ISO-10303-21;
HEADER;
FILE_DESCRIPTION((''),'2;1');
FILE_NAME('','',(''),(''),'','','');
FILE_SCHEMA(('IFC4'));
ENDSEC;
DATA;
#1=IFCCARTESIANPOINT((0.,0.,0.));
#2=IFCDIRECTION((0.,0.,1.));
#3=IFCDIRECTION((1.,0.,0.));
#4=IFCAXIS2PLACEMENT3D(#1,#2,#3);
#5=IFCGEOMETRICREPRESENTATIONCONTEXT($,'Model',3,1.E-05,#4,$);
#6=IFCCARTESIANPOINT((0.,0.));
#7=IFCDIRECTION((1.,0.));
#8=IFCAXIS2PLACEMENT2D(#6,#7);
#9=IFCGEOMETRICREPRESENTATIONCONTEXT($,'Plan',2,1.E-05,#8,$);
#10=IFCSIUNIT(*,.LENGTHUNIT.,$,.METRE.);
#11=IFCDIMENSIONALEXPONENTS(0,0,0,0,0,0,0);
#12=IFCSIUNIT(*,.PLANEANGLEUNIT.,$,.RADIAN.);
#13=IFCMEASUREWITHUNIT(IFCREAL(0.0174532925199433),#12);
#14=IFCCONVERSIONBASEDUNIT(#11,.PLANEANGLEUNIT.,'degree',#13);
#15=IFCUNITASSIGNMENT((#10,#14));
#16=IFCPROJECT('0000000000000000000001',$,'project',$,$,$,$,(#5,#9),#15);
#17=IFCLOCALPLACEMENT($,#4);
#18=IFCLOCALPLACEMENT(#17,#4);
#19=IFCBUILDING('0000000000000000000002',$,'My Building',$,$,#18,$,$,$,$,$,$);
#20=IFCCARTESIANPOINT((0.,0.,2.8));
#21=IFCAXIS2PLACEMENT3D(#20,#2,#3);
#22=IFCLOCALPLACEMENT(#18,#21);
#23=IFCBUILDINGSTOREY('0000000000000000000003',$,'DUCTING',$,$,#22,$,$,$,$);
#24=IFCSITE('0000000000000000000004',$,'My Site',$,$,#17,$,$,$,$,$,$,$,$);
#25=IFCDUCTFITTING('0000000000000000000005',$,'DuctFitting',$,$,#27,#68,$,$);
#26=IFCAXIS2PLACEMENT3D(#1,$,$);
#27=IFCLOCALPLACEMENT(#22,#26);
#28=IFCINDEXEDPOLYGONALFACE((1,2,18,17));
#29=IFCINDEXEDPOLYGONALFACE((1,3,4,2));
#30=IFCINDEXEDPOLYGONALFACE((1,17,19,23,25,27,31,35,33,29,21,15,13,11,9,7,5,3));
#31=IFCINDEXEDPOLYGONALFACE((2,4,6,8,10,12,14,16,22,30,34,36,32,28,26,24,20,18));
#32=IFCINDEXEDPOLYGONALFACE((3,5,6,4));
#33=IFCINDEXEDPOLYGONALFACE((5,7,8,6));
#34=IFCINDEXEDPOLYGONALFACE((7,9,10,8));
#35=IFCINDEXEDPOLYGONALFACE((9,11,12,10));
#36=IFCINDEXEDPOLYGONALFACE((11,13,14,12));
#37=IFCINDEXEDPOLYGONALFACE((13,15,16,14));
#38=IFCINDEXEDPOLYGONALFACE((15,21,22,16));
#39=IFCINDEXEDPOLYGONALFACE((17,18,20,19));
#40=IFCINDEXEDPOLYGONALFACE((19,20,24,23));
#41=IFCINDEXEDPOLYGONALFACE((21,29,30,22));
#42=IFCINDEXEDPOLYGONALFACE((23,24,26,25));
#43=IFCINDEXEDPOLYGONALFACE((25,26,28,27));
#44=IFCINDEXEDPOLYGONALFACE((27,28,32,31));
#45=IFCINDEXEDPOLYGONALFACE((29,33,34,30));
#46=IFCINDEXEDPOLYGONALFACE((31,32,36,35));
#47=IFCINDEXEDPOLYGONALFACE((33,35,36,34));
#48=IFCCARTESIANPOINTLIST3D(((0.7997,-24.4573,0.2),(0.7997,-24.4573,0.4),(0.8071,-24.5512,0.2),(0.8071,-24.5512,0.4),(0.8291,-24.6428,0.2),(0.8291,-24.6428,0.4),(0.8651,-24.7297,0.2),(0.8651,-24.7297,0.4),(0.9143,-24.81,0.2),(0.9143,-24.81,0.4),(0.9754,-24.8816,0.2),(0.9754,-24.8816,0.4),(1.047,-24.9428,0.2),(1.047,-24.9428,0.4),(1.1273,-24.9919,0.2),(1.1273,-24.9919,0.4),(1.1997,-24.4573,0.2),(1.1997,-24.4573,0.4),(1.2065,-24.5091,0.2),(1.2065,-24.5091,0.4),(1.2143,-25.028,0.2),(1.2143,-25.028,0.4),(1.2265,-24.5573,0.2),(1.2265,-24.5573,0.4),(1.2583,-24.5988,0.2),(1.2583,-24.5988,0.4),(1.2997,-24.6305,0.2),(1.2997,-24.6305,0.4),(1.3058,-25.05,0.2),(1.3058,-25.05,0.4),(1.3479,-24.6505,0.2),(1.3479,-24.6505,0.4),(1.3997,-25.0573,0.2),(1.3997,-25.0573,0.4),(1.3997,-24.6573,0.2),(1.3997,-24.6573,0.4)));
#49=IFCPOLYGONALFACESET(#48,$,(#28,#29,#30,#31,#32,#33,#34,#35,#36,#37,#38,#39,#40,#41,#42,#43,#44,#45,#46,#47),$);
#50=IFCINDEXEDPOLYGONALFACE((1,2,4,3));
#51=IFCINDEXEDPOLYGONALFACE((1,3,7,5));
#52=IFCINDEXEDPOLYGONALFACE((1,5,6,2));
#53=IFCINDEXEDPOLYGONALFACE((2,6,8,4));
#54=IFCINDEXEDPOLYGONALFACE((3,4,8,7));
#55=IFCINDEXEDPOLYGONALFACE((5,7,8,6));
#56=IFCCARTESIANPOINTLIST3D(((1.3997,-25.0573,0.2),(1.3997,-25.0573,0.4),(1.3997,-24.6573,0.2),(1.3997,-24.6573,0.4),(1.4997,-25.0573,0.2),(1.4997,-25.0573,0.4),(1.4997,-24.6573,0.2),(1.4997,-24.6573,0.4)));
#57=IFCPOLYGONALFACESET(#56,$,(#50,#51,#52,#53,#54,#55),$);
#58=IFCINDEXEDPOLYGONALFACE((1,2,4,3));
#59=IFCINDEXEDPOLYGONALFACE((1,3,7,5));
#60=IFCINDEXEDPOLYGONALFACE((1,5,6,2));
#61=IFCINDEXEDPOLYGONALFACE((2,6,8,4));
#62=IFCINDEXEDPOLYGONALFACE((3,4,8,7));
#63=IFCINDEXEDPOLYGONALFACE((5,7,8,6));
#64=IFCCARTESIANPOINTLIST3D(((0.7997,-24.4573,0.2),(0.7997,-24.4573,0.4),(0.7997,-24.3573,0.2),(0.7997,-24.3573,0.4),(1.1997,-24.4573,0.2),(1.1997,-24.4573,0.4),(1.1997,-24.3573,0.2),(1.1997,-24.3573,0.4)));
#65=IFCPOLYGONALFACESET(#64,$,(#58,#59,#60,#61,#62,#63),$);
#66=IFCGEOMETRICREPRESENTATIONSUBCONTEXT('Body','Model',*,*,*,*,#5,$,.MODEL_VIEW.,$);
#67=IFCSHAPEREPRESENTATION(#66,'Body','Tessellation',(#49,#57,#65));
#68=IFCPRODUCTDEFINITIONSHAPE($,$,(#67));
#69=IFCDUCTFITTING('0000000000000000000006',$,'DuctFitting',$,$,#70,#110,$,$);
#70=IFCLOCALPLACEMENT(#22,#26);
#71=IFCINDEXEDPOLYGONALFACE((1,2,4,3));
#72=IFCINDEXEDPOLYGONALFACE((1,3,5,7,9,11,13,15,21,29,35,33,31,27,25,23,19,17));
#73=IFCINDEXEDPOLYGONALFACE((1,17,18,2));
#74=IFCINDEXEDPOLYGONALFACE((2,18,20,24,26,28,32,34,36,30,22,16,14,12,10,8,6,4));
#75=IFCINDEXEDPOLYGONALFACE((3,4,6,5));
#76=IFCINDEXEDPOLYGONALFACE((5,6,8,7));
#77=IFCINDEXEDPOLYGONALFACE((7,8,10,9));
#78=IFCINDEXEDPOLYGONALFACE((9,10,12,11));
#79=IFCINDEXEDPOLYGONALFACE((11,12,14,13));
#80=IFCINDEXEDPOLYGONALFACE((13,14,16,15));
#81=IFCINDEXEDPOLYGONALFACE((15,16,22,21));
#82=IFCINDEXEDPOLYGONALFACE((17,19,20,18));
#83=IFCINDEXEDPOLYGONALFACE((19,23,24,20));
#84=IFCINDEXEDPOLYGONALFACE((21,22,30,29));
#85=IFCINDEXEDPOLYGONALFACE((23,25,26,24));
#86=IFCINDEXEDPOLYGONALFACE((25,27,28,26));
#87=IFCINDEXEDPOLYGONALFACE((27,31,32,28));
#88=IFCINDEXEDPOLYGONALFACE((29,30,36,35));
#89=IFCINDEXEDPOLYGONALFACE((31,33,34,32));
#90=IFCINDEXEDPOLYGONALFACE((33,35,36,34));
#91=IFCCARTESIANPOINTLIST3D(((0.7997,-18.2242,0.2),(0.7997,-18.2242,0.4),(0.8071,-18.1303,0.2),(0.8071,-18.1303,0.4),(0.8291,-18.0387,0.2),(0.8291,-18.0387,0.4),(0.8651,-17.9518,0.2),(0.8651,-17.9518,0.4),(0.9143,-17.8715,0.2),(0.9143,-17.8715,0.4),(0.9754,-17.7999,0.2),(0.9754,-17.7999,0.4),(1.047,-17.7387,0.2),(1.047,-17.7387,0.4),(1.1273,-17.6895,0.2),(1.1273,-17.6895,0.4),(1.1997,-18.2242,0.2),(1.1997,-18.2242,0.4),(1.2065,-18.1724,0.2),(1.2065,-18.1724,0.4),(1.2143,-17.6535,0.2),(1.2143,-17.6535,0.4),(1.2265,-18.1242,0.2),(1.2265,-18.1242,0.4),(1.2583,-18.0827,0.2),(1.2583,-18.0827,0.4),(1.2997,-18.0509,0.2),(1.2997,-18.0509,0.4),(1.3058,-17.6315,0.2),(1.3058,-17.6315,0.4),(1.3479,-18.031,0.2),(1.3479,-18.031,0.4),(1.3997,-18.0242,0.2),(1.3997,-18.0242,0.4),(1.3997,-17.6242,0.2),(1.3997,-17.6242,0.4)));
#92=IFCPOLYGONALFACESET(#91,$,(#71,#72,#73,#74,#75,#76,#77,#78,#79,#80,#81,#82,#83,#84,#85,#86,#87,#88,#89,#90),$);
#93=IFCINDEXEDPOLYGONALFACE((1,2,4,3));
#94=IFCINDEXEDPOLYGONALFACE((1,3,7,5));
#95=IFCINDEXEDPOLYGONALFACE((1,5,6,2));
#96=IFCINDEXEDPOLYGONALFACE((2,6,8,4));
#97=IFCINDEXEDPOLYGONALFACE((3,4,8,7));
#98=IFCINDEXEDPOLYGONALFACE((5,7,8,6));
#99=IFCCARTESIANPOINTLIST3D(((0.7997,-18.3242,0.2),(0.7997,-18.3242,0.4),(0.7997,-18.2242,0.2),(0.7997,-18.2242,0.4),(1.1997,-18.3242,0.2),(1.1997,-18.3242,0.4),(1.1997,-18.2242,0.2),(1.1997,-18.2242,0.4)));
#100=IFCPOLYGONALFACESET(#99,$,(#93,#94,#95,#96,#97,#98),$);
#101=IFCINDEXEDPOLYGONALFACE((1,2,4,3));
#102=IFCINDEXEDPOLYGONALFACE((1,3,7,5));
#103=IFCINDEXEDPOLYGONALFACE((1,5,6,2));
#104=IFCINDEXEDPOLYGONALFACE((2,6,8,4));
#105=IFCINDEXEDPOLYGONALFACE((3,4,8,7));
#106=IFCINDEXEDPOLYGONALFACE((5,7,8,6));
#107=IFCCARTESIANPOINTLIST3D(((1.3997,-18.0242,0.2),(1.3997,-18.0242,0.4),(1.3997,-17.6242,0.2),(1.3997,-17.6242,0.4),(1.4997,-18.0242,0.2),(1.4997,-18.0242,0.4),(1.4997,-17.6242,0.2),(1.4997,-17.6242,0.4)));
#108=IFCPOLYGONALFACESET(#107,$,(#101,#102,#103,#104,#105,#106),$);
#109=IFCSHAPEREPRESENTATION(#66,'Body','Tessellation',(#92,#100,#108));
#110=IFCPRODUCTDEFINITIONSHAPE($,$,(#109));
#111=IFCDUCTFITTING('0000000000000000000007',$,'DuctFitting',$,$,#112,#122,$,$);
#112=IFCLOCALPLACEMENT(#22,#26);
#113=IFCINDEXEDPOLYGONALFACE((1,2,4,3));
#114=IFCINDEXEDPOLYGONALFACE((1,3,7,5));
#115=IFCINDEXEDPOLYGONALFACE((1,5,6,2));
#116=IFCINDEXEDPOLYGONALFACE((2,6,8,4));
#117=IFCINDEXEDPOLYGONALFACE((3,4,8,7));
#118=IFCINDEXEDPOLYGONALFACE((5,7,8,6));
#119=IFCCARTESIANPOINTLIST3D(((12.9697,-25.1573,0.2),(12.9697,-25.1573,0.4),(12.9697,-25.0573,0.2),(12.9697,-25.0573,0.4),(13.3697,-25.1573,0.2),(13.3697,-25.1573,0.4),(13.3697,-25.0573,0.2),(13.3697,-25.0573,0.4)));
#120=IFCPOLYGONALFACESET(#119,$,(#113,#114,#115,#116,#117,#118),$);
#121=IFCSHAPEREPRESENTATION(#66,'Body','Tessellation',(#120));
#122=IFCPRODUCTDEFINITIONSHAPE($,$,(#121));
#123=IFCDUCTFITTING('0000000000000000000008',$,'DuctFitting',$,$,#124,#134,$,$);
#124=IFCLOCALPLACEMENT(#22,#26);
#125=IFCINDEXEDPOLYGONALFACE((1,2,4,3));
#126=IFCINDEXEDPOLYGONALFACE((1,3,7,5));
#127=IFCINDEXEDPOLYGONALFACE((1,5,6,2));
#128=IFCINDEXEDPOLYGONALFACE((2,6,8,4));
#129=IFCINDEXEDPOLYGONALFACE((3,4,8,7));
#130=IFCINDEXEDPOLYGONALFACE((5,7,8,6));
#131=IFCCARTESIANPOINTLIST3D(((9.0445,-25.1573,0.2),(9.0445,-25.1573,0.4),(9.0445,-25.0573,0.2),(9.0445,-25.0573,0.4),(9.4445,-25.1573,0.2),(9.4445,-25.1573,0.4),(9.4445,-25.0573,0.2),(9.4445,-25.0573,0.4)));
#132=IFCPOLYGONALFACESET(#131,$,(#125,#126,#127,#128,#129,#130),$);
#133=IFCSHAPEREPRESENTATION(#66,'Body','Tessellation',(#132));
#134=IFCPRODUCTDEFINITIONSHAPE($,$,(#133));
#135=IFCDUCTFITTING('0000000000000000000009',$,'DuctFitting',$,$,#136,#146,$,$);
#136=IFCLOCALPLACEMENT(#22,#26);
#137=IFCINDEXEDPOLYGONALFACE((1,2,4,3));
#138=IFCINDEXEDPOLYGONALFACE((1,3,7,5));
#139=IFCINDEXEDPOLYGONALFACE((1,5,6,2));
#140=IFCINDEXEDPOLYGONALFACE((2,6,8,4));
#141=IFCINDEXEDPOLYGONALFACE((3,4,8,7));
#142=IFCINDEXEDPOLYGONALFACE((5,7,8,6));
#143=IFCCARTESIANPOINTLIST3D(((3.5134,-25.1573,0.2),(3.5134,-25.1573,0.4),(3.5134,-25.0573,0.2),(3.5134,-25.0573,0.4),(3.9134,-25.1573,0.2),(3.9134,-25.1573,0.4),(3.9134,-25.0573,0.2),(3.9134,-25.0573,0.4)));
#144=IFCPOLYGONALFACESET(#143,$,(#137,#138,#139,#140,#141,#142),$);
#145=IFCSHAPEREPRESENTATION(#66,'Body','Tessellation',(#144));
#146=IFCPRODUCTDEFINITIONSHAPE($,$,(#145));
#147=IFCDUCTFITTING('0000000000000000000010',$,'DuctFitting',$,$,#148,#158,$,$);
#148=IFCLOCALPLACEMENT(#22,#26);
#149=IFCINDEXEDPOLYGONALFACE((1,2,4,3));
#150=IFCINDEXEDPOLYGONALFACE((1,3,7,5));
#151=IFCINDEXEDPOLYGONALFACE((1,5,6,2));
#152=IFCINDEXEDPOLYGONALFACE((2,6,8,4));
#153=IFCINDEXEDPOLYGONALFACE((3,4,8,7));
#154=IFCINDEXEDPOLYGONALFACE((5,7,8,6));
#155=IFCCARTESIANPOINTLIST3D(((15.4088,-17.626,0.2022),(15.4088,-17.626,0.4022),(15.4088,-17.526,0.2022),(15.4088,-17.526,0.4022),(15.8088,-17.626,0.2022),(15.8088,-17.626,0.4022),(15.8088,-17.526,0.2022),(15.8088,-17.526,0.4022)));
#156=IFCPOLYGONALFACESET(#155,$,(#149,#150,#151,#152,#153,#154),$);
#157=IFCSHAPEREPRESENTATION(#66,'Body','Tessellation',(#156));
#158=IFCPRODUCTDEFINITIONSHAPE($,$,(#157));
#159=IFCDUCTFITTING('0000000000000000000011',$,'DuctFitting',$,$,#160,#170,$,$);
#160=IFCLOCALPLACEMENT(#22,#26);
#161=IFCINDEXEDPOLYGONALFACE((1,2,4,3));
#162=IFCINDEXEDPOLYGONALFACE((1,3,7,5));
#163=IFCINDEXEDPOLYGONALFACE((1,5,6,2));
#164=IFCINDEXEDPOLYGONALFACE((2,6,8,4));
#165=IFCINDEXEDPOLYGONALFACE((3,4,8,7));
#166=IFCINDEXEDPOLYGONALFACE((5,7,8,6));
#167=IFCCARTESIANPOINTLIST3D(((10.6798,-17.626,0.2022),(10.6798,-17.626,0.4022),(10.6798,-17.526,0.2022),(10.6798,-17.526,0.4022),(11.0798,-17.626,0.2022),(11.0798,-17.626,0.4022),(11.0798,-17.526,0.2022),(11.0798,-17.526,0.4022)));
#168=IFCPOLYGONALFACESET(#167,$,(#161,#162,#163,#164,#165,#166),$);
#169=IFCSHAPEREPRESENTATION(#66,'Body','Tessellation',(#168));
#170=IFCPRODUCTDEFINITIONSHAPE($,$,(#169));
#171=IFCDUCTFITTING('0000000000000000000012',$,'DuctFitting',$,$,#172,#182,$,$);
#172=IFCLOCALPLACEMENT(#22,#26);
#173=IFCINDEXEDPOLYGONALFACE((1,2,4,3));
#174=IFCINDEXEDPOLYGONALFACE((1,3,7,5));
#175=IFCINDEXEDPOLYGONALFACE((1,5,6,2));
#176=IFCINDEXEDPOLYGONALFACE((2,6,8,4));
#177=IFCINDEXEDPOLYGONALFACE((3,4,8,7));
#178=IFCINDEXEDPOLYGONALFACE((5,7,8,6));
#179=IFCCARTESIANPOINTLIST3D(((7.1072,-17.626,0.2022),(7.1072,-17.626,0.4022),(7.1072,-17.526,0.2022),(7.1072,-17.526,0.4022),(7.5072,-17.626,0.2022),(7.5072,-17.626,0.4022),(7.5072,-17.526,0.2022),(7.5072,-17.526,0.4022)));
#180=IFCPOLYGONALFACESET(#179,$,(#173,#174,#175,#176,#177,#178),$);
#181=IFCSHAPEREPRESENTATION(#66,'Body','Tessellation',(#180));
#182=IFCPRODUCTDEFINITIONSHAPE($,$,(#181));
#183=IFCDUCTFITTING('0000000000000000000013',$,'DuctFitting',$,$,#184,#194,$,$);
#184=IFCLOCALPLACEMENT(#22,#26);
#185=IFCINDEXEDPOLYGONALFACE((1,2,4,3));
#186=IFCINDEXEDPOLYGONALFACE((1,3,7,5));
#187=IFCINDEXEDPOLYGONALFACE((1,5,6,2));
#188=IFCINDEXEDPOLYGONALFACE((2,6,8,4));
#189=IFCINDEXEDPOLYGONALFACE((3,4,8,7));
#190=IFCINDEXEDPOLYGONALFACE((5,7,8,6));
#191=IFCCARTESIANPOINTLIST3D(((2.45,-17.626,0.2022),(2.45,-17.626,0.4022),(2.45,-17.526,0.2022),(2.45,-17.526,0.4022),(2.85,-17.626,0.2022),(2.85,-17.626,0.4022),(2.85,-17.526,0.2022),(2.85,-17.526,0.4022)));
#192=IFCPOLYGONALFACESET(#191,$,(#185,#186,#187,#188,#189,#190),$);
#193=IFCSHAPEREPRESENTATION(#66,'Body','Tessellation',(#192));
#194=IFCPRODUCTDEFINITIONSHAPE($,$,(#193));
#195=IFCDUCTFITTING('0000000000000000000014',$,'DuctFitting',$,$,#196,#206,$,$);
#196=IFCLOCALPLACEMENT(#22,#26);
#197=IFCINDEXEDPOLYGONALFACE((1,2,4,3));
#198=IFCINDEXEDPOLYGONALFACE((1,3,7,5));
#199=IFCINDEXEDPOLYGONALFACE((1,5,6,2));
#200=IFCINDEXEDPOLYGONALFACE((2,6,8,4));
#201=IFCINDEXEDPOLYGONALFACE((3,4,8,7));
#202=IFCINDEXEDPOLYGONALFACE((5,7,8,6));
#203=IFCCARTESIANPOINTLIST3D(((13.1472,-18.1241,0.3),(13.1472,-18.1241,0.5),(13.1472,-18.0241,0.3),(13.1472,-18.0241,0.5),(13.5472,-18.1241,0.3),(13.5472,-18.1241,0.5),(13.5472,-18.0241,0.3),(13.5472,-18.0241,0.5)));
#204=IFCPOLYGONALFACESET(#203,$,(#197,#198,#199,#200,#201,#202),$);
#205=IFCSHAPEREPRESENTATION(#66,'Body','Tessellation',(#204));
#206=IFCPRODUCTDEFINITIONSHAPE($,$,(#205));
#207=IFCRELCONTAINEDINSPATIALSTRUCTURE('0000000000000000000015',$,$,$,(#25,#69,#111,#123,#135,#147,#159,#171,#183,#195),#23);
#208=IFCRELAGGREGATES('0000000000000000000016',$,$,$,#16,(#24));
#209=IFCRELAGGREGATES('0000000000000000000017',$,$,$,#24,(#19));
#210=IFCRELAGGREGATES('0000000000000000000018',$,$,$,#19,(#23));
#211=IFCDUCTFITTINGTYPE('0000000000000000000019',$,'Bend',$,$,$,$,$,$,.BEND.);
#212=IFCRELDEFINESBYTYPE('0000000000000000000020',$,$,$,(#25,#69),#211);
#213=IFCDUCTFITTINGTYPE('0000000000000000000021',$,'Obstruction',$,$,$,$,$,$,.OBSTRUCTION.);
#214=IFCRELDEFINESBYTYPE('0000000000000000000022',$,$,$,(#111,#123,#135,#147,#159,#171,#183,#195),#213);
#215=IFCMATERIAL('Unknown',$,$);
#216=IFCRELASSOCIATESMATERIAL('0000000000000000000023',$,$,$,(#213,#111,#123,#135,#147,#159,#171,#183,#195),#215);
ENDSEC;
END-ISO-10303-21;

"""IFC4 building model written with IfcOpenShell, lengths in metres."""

from ifc_helpers import new_model, entity, si_unit, converted_unit, frame, origin_with_axes, origin_2d_with_axis, place, context, subcontext, project, spatial, line, arc, indexed_curve, rectangle, outline, extrude, source, transform, mapped, material, material_profile, profile_set, profile_usage, type_object, type_shapes, element, save


model = new_model("IFC4")

# Units and contexts
model_context = context("Model", 3, precision=1e-05, world=origin_with_axes())
plan_context = context("Plan", 2, precision=1e-05, world=origin_2d_with_axis())
body_context = subcontext(model_context, "Body", "Model", "MODEL_VIEW")
ifc_project = project(units=[si_unit("LENGTHUNIT", "METRE"), converted_unit("PLANEANGLEUNIT", "degree", entity("IfcReal", 0.0174532925199433), si_unit("PLANEANGLEUNIT", "RADIAN"), dimensions=[0, 0, 0, 0, 0, 0, 0])], contexts=[model_context, plan_context])

# Site, building, storey
site_placement = place(None, origin_with_axes())
site = spatial("IfcSite", under=ifc_project, at=site_placement, Name="My Site")
building_placement = place(site_placement, origin_with_axes())
building = spatial("IfcBuilding", under=site, at=building_placement, Name="My Building")
storey_placement = place(building_placement, frame((0.0, 0.0, 2.8), z_axis=(0.0, 0.0, 1.0), x_axis=(1.0, 0.0, 0.0)))
storey = spatial("IfcBuildingStorey", under=building, at=storey_placement, Name="DUCTING")

# Shared definitions
ifc_material = material(Name="Unknown")

# Duct fittings
duct_fitting_type_1 = type_object("IfcDuctFittingType", Name="Bend", PredefinedType="BEND")
shared_shape = source(origin_with_axes(), body_context, "Body", "SweptSolid", [
    extrude(outline(indexed_curve([(-0.2, 0.0), (-0.2586, 0.1414), (-0.4, 0.2), (-0.4, 0.6), (0.0243, 0.4243), (0.2, 0.0)], segments=[arc(1, 2, 3), line(3, 4), arc(4, 5, 6), line(6, 1)])), frame((0.0, -0.1, 0.1), z_axis=(0.0, -1.0, 0.0), x_axis=(1.0, 0.0, 0.0)), (0.0, 0.0, -1.0), 0.2),
    extrude(rectangle(XDim=0.4, YDim=0.2), origin_with_axes(), (0.0, 0.0, 1.0), 0.1),
    extrude(rectangle(XDim=0.4, YDim=0.2), frame((-0.4, 0.0, 0.5), z_axis=(-1.0, 0.0, 0.0), x_axis=(0.0, 0.0, -1.0)), (0.0, 0.0, 1.0), 0.1),
])
type_shapes(duct_fitting_type_1, [shared_shape])
for number, where, z_axis, x_axis, name in (
    (1, (1.4997, -24.8573, 0.3), (-1.0, 0.0, 0.0), (0.0, -1.0, 0.0), "DuctFitting"),
    (2, (0.9997, -18.3242, 0.3), (0.0, 1.0, 0.000006), (-1.0, 0.0, 0.0), "DuctFitting"),
):
    element("IfcDuctFitting", number, at=place(storey_placement, frame(where, z_axis=z_axis, x_axis=x_axis)), inside=storey, type_object=duct_fitting_type_1, Name=name, context=body_context, shape_type="MappedRepresentation", body=[
        mapped(shared_shape, transform((0.0, 0.0, 0.0), x_axis=(1.0, 0.0, 0.0), y_axis=(0.0, 1.0, 0.0), z_axis=(0.0, 0.0, 1.0), scale=1.0)),
    ])
ifc_material_profile_1 = material_profile(ifc_material, rectangle(XDim=0.4, YDim=0.2))
ifc_profile_set_1 = profile_set([ifc_material_profile_1])
ifc_profile_usage_1 = profile_usage(ifc_profile_set_1, cardinal=5)
duct_fitting_type_2 = type_object("IfcDuctFittingType", Name="Obstruction", PredefinedType="OBSTRUCTION", material=ifc_profile_set_1)
duct_fitting_1_placement = place(storey_placement, frame((13.1697, -25.0573, 0.3), z_axis=(0.0, -1.0, 0.0), x_axis=(1.0, 0.0, 0.0)))
element("IfcDuctFitting", 3, at=duct_fitting_1_placement, inside=storey, type_object=duct_fitting_type_2, material=ifc_profile_usage_1, Name="DuctFitting", context=body_context, shape_type="SweptSolid", body=[
    extrude(rectangle(XDim=0.4, YDim=0.2), origin_with_axes(), (0.0, 0.0, 1.0), 0.1),
])
ifc_profile_usage_2 = profile_usage(ifc_profile_set_1, cardinal=5)
duct_fitting_2_placement = place(storey_placement, frame((9.2445, -25.0573, 0.3), z_axis=(0.0, -1.0, 0.0), x_axis=(1.0, 0.0, 0.0)))
element("IfcDuctFitting", 4, at=duct_fitting_2_placement, inside=storey, type_object=duct_fitting_type_2, material=ifc_profile_usage_2, Name="DuctFitting", context=body_context, shape_type="SweptSolid", body=[
    extrude(rectangle(XDim=0.4, YDim=0.2), origin_with_axes(), (0.0, 0.0, 1.0), 0.1),
])
ifc_profile_usage_3 = profile_usage(ifc_profile_set_1, cardinal=5)
duct_fitting_3_placement = place(storey_placement, frame((3.7134, -25.0573, 0.3), z_axis=(0.0, -1.0, 0.0), x_axis=(1.0, 0.0, 0.0)))
element("IfcDuctFitting", 5, at=duct_fitting_3_placement, inside=storey, type_object=duct_fitting_type_2, material=ifc_profile_usage_3, Name="DuctFitting", context=body_context, shape_type="SweptSolid", body=[
    extrude(rectangle(XDim=0.4, YDim=0.2), origin_with_axes(), (0.0, 0.0, 1.0), 0.1),
])
ifc_profile_usage_4 = profile_usage(ifc_profile_set_1, cardinal=5)
duct_fitting_4_placement = place(storey_placement, frame((15.6088, -17.526, 0.3022), z_axis=(0.0, -1.0, 0.000003), x_axis=(1.0, 0.0, 0.0)))
element("IfcDuctFitting", 6, at=duct_fitting_4_placement, inside=storey, type_object=duct_fitting_type_2, material=ifc_profile_usage_4, Name="DuctFitting", context=body_context, shape_type="SweptSolid", body=[
    extrude(rectangle(XDim=0.4, YDim=0.2), origin_with_axes(), (0.0, 0.0, 1.0), 0.1),
])
ifc_profile_usage_5 = profile_usage(ifc_profile_set_1, cardinal=5)
duct_fitting_5_placement = place(storey_placement, frame((10.8798, -17.526, 0.3022), z_axis=(0.0, -1.0, 0.000003), x_axis=(1.0, 0.0, 0.0)))
element("IfcDuctFitting", 7, at=duct_fitting_5_placement, inside=storey, type_object=duct_fitting_type_2, material=ifc_profile_usage_5, Name="DuctFitting", context=body_context, shape_type="SweptSolid", body=[
    extrude(rectangle(XDim=0.4, YDim=0.2), origin_with_axes(), (0.0, 0.0, 1.0), 0.1),
])
ifc_profile_usage_6 = profile_usage(ifc_profile_set_1, cardinal=5)
duct_fitting_6_placement = place(storey_placement, frame((7.3072, -17.526, 0.3022), z_axis=(0.0, -1.0, 0.000003), x_axis=(1.0, 0.0, 0.0)))
element("IfcDuctFitting", 8, at=duct_fitting_6_placement, inside=storey, type_object=duct_fitting_type_2, material=ifc_profile_usage_6, Name="DuctFitting", context=body_context, shape_type="SweptSolid", body=[
    extrude(rectangle(XDim=0.4, YDim=0.2), origin_with_axes(), (0.0, 0.0, 1.0), 0.1),
])
ifc_profile_usage_7 = profile_usage(ifc_profile_set_1, cardinal=5)
duct_fitting_7_placement = place(storey_placement, frame((2.65, -17.526, 0.3022), z_axis=(0.0, -1.0, 0.000003), x_axis=(1.0, 0.0, 0.0)))
element("IfcDuctFitting", 9, at=duct_fitting_7_placement, inside=storey, type_object=duct_fitting_type_2, material=ifc_profile_usage_7, Name="DuctFitting", context=body_context, shape_type="SweptSolid", body=[
    extrude(rectangle(XDim=0.4, YDim=0.2), origin_with_axes(), (0.0, 0.0, 1.0), 0.1),
])
ifc_profile_usage_8 = profile_usage(ifc_profile_set_1, cardinal=5)
duct_fitting_8_placement = place(storey_placement, frame((13.3472, -18.0241, 0.4), z_axis=(0.0, -1.0, 0.000005), x_axis=(1.0, 0.0, 0.0)))
element("IfcDuctFitting", 10, at=duct_fitting_8_placement, inside=storey, type_object=duct_fitting_type_2, material=ifc_profile_usage_8, Name="DuctFitting", context=body_context, shape_type="SweptSolid", body=[
    extrude(rectangle(XDim=0.4, YDim=0.2), origin_with_axes(), (0.0, 0.0, 1.0), 0.1),
])

save(model, "model.ifc")
